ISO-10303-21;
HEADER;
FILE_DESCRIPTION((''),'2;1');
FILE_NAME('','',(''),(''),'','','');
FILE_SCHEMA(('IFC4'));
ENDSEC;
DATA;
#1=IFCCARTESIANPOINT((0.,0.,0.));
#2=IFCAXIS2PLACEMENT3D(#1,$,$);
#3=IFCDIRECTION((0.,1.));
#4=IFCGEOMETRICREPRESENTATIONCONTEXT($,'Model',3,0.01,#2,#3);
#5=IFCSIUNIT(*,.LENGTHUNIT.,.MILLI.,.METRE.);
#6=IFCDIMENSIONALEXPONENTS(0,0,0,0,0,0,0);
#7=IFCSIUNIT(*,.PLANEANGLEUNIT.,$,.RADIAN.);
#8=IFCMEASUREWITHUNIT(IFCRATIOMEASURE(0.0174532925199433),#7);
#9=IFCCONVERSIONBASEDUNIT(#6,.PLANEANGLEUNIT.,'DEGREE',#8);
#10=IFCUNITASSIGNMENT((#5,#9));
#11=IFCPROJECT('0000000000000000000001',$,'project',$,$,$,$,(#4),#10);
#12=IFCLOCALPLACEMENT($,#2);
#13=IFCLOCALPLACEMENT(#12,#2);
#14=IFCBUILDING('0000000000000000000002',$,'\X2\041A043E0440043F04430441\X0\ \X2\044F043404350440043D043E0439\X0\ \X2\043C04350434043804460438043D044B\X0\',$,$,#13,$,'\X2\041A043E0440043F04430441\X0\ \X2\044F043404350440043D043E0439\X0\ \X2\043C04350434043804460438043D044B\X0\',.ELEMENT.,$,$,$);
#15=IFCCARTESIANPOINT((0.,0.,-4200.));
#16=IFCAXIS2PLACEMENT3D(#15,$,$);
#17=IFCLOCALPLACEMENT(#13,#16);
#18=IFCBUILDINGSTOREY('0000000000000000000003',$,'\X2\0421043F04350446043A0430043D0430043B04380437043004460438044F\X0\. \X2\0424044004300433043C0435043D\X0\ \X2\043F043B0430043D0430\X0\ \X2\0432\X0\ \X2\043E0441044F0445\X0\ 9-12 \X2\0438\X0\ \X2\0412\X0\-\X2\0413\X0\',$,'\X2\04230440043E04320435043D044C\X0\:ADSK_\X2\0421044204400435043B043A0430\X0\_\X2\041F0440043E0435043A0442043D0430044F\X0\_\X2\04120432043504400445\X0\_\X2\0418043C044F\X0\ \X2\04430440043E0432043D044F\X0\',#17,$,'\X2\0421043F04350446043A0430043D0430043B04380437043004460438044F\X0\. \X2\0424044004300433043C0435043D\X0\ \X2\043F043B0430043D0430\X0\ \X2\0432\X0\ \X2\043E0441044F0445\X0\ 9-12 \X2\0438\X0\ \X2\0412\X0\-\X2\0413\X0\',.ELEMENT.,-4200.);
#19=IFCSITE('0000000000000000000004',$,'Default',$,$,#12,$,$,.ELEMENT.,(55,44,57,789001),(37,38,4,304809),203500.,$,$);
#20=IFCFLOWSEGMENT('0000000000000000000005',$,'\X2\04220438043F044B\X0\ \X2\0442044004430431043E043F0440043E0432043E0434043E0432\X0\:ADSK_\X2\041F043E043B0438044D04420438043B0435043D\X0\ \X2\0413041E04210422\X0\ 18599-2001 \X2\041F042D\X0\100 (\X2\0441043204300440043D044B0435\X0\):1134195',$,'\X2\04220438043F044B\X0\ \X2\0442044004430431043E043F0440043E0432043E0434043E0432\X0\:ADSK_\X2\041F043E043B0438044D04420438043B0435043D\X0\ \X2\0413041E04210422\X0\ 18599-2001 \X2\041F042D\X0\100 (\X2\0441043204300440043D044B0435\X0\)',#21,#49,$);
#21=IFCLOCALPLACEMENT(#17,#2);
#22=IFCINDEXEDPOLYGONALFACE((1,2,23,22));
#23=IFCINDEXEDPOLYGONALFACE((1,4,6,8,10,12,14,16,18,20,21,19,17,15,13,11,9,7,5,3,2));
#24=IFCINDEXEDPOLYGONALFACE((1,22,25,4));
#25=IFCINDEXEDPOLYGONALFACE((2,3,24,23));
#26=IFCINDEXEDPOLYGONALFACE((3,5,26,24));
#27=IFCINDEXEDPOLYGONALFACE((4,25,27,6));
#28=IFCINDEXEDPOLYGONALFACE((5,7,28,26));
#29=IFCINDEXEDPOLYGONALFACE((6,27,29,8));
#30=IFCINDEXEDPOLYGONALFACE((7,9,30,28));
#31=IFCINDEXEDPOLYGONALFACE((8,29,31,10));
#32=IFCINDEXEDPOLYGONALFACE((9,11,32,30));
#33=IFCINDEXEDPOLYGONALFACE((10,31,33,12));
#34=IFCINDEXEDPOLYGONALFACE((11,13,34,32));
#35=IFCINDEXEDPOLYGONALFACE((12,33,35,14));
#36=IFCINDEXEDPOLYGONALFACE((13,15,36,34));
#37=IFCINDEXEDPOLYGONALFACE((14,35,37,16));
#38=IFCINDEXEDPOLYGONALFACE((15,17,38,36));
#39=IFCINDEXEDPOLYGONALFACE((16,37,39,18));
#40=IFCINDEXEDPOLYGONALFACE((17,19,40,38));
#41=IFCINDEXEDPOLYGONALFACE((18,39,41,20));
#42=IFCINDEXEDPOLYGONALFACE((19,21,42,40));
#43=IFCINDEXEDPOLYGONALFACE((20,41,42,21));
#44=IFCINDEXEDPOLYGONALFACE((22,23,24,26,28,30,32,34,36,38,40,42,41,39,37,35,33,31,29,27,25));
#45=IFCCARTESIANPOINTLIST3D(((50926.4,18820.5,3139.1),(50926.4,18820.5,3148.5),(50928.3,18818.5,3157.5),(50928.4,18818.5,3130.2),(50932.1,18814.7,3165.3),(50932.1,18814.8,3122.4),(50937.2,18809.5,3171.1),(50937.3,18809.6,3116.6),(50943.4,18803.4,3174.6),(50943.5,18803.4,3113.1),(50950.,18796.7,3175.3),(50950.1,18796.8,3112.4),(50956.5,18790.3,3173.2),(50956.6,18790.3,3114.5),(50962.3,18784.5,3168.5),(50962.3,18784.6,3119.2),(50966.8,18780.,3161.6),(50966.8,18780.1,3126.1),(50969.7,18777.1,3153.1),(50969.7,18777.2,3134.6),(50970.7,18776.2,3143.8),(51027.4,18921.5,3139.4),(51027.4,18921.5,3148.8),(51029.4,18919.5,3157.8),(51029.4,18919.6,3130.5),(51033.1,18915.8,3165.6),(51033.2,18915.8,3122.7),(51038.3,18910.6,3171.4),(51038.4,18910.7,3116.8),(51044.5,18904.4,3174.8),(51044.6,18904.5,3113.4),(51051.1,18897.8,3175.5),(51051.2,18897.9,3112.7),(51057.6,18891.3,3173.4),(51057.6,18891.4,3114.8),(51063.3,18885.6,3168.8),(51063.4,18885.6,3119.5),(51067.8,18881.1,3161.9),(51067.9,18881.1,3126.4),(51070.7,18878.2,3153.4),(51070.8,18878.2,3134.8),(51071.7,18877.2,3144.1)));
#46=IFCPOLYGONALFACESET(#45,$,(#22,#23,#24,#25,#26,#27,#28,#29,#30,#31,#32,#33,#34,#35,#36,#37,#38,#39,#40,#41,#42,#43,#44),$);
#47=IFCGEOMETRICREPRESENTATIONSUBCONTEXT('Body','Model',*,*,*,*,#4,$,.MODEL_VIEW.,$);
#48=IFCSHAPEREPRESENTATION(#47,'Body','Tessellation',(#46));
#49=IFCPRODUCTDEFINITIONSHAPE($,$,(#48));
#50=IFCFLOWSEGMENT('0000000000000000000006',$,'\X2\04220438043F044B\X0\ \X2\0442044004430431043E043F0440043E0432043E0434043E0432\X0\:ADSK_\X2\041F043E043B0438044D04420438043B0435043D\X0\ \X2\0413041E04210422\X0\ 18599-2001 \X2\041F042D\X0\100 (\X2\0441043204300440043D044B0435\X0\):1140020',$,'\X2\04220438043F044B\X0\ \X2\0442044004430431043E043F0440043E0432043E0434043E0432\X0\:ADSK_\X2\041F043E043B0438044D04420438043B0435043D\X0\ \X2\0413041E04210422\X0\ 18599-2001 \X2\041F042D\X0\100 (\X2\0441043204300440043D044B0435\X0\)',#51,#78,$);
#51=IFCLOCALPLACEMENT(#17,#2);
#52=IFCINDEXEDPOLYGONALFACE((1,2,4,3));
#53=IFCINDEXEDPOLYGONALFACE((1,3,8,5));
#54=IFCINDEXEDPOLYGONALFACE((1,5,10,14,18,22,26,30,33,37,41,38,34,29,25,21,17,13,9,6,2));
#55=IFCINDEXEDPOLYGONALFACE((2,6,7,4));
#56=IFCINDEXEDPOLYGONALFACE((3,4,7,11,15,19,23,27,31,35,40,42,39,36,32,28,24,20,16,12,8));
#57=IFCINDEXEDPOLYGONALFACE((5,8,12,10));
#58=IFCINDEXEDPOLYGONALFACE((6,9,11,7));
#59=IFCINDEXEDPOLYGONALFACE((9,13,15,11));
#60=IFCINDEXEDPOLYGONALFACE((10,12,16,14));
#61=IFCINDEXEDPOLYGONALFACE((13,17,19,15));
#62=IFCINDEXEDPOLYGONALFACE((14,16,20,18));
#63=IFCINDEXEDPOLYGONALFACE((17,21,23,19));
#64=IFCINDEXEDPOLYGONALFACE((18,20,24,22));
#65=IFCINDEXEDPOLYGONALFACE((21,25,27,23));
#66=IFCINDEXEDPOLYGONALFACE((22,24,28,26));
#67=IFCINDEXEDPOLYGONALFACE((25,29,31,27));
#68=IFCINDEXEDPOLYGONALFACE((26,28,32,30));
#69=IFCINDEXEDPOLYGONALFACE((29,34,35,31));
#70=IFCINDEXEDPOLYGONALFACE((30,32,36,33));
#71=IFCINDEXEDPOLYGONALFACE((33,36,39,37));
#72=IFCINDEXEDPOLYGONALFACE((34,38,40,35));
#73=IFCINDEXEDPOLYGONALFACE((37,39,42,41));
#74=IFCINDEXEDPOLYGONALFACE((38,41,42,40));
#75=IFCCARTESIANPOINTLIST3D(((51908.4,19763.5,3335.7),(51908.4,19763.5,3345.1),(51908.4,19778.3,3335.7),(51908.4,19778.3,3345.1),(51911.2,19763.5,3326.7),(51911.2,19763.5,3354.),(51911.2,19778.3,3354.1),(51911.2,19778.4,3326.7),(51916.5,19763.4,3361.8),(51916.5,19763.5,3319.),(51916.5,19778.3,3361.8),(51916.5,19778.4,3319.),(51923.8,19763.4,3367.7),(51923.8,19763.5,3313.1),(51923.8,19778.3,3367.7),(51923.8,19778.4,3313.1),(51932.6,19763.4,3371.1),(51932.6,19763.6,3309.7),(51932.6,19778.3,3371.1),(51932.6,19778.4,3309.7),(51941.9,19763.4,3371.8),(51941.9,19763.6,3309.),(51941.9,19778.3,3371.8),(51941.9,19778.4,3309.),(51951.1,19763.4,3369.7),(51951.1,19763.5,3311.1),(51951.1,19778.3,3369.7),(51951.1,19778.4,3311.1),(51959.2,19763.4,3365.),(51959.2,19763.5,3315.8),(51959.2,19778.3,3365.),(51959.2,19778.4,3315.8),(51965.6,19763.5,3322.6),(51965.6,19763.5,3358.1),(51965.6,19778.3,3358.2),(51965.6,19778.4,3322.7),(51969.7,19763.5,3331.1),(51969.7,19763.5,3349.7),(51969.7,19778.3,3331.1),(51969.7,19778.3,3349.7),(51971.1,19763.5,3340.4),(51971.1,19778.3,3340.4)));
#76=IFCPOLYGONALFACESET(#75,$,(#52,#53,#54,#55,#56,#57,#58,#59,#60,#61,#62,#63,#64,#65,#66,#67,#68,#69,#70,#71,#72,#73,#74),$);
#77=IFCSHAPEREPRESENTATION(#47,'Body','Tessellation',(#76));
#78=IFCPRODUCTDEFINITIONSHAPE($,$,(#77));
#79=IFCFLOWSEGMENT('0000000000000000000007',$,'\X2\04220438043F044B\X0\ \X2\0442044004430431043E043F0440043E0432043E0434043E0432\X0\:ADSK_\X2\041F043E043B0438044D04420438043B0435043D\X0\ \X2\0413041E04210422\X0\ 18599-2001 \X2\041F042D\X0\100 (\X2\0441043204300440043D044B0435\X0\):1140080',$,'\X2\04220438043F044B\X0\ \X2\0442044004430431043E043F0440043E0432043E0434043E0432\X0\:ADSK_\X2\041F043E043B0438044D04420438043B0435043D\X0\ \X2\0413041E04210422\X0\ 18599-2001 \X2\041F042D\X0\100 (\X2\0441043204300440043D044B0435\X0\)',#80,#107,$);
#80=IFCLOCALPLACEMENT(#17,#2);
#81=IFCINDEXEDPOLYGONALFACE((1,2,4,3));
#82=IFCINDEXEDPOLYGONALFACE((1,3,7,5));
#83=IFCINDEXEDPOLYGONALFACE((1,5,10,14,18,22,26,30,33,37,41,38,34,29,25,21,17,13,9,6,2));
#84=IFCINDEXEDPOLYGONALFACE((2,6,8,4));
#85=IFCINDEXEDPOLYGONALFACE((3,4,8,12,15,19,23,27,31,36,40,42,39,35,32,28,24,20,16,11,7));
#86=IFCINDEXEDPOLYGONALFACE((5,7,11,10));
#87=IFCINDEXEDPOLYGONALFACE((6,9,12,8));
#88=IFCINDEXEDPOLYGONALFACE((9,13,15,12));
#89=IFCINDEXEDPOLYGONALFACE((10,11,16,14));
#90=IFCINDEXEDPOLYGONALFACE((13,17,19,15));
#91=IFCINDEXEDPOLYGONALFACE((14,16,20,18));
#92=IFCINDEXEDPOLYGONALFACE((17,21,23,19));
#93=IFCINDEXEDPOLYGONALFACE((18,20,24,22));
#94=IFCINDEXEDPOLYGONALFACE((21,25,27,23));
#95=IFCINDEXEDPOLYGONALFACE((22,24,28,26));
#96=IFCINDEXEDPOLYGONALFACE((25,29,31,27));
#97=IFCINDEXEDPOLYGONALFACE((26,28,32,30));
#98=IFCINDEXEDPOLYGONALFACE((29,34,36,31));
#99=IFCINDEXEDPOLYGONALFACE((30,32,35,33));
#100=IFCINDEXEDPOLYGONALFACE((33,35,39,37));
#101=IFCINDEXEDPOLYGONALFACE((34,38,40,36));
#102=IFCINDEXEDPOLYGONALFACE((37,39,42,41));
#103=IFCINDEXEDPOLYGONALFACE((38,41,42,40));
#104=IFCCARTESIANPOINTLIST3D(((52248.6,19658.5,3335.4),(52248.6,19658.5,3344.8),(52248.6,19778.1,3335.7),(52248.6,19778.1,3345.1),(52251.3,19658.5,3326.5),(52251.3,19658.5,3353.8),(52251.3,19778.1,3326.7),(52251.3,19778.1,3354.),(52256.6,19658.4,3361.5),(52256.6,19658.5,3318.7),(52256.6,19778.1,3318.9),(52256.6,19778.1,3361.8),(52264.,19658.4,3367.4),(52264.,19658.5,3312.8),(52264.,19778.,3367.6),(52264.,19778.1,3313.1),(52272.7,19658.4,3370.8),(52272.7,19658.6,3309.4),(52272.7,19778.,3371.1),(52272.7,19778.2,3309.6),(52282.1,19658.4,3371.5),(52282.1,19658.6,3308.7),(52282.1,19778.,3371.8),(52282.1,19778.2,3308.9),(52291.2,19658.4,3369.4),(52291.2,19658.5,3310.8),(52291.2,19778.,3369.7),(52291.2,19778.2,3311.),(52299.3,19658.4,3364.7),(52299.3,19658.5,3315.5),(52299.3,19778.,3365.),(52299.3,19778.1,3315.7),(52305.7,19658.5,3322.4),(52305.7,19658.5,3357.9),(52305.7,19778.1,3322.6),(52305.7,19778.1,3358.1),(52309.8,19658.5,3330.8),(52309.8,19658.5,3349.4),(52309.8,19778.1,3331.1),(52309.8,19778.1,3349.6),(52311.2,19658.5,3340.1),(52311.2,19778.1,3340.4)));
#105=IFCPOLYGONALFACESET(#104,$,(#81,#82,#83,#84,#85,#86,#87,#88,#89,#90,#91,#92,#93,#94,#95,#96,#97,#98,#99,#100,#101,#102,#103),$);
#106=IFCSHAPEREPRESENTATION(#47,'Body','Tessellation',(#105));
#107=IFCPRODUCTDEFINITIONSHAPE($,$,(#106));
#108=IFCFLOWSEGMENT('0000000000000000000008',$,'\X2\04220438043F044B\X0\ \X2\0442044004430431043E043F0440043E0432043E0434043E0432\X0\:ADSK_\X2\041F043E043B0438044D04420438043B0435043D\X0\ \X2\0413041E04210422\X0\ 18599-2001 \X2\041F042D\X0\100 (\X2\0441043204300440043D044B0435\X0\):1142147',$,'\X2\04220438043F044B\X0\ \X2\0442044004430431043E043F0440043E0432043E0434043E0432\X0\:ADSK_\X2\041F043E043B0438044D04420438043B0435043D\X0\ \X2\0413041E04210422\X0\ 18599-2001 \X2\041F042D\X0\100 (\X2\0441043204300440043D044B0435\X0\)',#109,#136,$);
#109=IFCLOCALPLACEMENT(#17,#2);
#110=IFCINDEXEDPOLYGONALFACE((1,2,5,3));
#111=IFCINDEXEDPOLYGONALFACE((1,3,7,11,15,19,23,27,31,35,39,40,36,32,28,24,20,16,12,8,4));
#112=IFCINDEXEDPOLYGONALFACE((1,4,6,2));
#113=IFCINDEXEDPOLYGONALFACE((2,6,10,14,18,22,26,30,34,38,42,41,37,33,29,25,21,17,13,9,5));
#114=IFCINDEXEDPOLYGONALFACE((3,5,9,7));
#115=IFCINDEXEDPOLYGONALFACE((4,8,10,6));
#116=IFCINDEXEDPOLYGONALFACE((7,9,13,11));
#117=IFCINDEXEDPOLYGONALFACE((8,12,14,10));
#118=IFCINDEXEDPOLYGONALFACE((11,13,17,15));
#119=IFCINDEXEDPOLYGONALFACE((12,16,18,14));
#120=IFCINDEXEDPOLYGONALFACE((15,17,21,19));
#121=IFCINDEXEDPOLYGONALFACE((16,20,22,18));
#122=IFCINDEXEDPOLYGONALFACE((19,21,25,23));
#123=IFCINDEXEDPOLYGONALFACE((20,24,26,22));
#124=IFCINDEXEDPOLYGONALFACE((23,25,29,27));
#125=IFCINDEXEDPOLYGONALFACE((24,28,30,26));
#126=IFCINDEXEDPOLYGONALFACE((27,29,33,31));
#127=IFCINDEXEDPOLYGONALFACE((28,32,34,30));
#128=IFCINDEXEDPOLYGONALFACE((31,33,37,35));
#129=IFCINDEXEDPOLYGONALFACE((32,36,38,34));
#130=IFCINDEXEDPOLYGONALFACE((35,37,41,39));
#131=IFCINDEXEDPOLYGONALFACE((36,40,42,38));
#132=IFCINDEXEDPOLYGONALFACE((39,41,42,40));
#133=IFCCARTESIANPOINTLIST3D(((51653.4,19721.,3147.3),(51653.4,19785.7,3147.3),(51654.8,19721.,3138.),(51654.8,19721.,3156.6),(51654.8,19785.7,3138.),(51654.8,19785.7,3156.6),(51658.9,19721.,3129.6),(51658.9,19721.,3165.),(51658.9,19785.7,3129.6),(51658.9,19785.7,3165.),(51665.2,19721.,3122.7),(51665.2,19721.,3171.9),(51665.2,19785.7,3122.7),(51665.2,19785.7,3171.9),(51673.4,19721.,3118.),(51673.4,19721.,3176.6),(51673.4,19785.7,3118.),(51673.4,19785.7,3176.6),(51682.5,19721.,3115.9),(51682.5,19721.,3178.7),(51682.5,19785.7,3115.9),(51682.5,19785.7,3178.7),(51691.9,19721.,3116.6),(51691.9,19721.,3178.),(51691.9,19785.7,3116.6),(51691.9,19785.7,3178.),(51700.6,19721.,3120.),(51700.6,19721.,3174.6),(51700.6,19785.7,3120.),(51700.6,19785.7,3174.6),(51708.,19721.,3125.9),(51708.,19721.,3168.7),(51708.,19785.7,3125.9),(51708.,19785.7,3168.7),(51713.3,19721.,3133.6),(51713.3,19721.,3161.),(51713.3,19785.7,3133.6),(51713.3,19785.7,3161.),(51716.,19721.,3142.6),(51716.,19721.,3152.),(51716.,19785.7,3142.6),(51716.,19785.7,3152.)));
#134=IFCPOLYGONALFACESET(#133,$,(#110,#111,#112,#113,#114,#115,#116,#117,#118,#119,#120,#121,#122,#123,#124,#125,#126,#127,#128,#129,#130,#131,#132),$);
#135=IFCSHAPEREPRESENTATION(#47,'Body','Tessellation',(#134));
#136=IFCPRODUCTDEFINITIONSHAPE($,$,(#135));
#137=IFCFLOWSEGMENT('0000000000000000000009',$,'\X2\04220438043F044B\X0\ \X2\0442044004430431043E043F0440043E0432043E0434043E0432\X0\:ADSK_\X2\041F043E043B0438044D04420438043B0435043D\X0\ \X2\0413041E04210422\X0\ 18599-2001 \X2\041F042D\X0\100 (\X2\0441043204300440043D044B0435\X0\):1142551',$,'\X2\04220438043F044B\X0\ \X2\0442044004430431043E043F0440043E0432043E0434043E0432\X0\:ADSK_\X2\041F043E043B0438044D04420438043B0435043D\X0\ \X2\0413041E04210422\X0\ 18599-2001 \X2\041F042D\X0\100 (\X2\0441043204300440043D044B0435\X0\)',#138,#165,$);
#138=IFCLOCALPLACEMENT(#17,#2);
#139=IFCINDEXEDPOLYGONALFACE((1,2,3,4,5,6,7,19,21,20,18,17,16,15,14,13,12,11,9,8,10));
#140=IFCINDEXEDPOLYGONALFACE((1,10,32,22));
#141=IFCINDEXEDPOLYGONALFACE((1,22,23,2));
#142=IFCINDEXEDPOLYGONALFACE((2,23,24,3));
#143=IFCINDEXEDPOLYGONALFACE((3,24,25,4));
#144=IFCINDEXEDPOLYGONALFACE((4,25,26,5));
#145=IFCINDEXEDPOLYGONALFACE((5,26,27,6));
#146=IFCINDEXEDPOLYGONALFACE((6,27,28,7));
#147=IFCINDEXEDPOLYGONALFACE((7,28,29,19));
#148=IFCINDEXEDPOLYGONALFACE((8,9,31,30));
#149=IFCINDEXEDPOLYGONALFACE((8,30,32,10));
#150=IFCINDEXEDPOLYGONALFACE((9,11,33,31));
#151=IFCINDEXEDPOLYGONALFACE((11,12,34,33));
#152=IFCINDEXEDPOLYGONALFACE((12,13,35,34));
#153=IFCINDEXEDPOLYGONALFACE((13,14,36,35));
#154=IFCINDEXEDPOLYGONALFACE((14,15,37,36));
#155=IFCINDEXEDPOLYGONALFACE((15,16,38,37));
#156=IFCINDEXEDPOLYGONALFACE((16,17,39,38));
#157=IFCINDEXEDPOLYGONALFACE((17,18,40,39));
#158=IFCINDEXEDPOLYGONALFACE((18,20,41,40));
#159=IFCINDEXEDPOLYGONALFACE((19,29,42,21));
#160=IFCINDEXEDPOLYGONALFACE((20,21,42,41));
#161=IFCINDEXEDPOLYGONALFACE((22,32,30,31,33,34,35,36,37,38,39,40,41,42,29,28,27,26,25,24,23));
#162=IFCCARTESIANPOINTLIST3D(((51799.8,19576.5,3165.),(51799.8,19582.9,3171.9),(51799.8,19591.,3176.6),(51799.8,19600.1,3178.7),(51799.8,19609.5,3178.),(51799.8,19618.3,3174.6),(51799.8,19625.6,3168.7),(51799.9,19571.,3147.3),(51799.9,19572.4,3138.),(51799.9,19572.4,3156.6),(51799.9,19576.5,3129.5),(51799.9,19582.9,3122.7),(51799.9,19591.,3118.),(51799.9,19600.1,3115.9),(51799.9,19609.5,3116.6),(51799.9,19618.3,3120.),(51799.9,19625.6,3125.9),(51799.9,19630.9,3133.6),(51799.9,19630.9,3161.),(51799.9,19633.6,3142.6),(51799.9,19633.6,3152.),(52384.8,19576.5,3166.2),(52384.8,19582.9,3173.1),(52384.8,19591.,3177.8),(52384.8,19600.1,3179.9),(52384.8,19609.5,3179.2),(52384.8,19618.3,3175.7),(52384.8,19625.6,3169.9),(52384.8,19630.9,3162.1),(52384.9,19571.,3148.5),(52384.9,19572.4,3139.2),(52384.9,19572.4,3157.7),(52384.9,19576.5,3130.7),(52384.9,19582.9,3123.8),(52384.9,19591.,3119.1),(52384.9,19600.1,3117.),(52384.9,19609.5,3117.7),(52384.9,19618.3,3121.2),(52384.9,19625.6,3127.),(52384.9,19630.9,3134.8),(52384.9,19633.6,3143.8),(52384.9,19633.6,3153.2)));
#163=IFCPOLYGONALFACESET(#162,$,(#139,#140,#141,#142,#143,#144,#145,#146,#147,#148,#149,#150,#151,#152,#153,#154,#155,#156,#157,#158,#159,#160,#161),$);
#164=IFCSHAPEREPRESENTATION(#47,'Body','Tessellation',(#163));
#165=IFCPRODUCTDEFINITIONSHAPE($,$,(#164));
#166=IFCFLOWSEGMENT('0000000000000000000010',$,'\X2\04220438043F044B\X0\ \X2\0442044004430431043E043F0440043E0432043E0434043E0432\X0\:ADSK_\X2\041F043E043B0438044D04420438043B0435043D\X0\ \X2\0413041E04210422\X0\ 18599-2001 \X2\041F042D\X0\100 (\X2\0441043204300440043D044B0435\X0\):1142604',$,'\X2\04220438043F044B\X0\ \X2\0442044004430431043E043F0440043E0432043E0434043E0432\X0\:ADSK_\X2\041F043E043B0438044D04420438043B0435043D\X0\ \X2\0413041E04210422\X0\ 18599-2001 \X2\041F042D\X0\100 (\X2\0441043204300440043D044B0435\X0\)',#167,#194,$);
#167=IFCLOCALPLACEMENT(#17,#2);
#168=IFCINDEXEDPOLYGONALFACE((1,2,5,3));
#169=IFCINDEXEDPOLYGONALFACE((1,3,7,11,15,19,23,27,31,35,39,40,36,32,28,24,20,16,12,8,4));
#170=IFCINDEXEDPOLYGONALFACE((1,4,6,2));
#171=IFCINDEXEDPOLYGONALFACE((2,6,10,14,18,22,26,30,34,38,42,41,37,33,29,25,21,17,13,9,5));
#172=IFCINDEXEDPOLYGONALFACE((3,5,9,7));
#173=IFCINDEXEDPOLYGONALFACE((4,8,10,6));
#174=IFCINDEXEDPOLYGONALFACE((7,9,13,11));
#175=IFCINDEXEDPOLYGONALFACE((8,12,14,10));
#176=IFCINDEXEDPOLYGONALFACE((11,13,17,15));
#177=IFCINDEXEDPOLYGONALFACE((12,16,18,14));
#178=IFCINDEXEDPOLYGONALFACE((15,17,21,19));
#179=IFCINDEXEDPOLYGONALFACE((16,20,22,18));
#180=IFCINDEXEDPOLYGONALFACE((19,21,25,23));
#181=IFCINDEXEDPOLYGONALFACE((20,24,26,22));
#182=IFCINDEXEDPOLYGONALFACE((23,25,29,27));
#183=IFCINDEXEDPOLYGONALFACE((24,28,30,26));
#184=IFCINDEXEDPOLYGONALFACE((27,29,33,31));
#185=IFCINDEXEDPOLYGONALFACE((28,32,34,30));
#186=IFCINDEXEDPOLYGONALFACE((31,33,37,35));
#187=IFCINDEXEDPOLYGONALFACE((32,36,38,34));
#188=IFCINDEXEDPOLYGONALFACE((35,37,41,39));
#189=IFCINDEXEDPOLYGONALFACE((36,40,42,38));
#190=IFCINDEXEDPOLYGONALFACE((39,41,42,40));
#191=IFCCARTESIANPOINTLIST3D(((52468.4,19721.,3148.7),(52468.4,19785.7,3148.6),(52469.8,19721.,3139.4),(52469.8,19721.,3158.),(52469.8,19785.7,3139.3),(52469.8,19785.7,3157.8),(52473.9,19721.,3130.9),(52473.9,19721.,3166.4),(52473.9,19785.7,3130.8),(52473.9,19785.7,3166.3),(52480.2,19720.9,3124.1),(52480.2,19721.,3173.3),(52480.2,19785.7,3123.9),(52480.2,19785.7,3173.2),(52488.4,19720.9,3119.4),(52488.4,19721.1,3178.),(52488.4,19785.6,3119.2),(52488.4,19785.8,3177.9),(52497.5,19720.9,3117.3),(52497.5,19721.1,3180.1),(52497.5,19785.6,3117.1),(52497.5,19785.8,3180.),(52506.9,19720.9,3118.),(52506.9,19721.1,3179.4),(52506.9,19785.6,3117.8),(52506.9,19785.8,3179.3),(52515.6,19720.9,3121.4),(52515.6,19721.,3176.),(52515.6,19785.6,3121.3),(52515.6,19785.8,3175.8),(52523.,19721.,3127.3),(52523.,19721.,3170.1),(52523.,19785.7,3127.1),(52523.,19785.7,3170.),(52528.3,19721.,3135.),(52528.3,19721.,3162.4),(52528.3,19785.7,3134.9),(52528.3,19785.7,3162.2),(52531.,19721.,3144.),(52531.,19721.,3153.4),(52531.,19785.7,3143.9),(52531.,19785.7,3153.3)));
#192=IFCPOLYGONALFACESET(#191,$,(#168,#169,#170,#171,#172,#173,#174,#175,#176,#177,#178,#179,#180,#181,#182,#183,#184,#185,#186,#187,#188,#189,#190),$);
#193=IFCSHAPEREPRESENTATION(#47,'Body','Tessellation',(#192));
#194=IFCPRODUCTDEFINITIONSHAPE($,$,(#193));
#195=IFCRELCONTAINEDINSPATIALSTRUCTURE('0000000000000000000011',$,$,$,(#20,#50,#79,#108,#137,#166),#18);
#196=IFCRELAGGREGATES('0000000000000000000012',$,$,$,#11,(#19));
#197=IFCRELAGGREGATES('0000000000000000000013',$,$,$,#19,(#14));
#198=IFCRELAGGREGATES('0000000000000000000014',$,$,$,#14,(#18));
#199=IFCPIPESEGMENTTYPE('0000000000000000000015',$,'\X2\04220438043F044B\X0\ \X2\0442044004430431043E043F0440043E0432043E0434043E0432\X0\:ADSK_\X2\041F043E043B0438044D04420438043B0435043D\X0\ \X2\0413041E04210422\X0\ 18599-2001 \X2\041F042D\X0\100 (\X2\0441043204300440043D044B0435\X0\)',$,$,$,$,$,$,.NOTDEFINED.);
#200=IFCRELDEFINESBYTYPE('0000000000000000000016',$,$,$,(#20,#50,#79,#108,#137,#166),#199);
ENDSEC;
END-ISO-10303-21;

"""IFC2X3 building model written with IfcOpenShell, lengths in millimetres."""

from ifc_helpers import new_model, entity, si_unit, converted_unit, direction, frame, origin, origin_2d_with_axis, place, context, subcontext, project, spatial, circle, extrude, type_object, element, save


model = new_model("IFC2X3")

# Units and contexts
model_context = context("Model", 3, precision=0.01, world=origin(), true_north=direction((0.0, 1.0)))
body_context = subcontext(model_context, "Body", "Model", "MODEL_VIEW")
ifc_project = project(units=[si_unit("LENGTHUNIT", "METRE", prefix="MILLI"), converted_unit("PLANEANGLEUNIT", "DEGREE", entity("IfcRatioMeasure", 0.0174532925199433), si_unit("PLANEANGLEUNIT", "RADIAN"), dimensions=[0, 0, 0, 0, 0, 0, 0])], contexts=[model_context])

# Site, building, storey
site_placement = place(None, origin())
site = spatial("IfcSite", under=ifc_project, at=site_placement, Name="Default", CompositionType="ELEMENT", RefLatitude=(55, 44, 57, 789001), RefLongitude=(37, 38, 4, 304809), RefElevation=203500.0)
building_placement = place(site_placement, origin())
building = spatial("IfcBuilding", under=site, at=building_placement, Name="Корпус ядерной медицины", LongName="Корпус ядерной медицины", CompositionType="ELEMENT")
storey_placement = place(building_placement, frame((0.0, 0.0, -4200.0)))
storey = spatial("IfcBuildingStorey", under=building, at=storey_placement, Name="Спецканализация. Фрагмен плана в осях 9-12 и В-Г", ObjectType="Уровень:ADSK_Стрелка_Проектная_Вверх_Имя уровня", LongName="Спецканализация. Фрагмен плана в осях 9-12 и В-Г", CompositionType="ELEMENT", Elevation=-4200.0)

# Flow segments
pipe_segment_type = type_object("IfcPipeSegmentType", Name="Типы трубопроводов:ADSK_Полиэтилен ГОСТ 18599-2001 ПЭ100 (сварные)", PredefinedType="NOTDEFINED")
flow_segment_1_placement = place(storey_placement, frame((50924.6, 18774.6, 3110.7)))
element("IfcFlowSegment", 1, at=flow_segment_1_placement, inside=storey, type_object=pipe_segment_type, Name="Типы трубопроводов:ADSK_Полиэтилен ГОСТ 18599-2001 ПЭ100 (сварные):1134195", ObjectType="Типы трубопроводов:ADSK_Полиэтилен ГОСТ 18599-2001 ПЭ100 (сварные)", context=body_context, shape_type="SweptSolid", body=[
    extrude(circle(Radius=31.5, at=origin_2d_with_axis()), frame((23.9, 23.9, 33.1), z_axis=(0.707105, 0.707105, 0.002), x_axis=(0.707107, -0.707107, 0.0)), (0.0, 0.0, 1.0), 142.9),
])
flow_segment_2_placement = place(storey_placement, frame((51906.5, 19763.4, 3307.3)))
element("IfcFlowSegment", 2, at=flow_segment_2_placement, inside=storey, type_object=pipe_segment_type, Name="Типы трубопроводов:ADSK_Полиэтилен ГОСТ 18599-2001 ПЭ100 (сварные):1140020", ObjectType="Типы трубопроводов:ADSK_Полиэтилен ГОСТ 18599-2001 ПЭ100 (сварные)", context=body_context, shape_type="SweptSolid", body=[
    extrude(circle(Radius=31.5, at=origin_2d_with_axis()), frame((33.1, 0.1, 33.1), z_axis=(0.0, 0.999998, 0.001994), x_axis=(1.0, 0.0, 0.0)), (0.0, 0.0, 1.0), 14.8),
])
flow_segment_3_placement = place(storey_placement, frame((52246.6, 19658.4, 3307.0)))
element("IfcFlowSegment", 3, at=flow_segment_3_placement, inside=storey, type_object=pipe_segment_type, Name="Типы трубопроводов:ADSK_Полиэтилен ГОСТ 18599-2001 ПЭ100 (сварные):1140080", ObjectType="Типы трубопроводов:ADSK_Полиэтилен ГОСТ 18599-2001 ПЭ100 (сварные)", context=body_context, shape_type="SweptSolid", body=[
    extrude(circle(Radius=31.5, at=origin_2d_with_axis()), frame((33.1, 0.1, 33.1), z_axis=(0.0, 0.999998, 0.002), x_axis=(1.0, 0.0, 0.0)), (0.0, 0.0, 1.0), 119.6),
])
flow_segment_4_placement = place(storey_placement, frame((51651.8, 19721.0, 3114.2)))
element("IfcFlowSegment", 4, at=flow_segment_4_placement, inside=storey, type_object=pipe_segment_type, Name="Типы трубопроводов:ADSK_Полиэтилен ГОСТ 18599-2001 ПЭ100 (сварные):1142147", ObjectType="Типы трубопроводов:ADSK_Полиэтилен ГОСТ 18599-2001 ПЭ100 (сварные)", context=body_context, shape_type="SweptSolid", body=[
    extrude(circle(Radius=31.5, at=origin_2d_with_axis()), frame((33.1, 0.0, 33.1), z_axis=(0.000002, 1.0, 0.0), x_axis=(-1.0, 0.000002, 0.0)), (0.0, 0.0, 1.0), 64.7),
])
flow_segment_5_placement = place(storey_placement, frame((51799.8, 19569.4, 3114.2)))
element("IfcFlowSegment", 5, at=flow_segment_5_placement, inside=storey, type_object=pipe_segment_type, Name="Типы трубопроводов:ADSK_Полиэтилен ГОСТ 18599-2001 ПЭ100 (сварные):1142551", ObjectType="Типы трубопроводов:ADSK_Полиэтилен ГОСТ 18599-2001 ПЭ100 (сварные)", context=body_context, shape_type="SweptSolid", body=[
    extrude(circle(Radius=31.5, at=origin_2d_with_axis()), frame((0.1, 33.1, 33.1), z_axis=(0.999998, 0.0, 0.001994), x_axis=(0.0, -1.0, 0.0)), (0.0, 0.0, 1.0), 585.0),
])
flow_segment_6_placement = place(storey_placement, frame((52466.8, 19720.9, 3115.5)))
element("IfcFlowSegment", 6, at=flow_segment_6_placement, inside=storey, type_object=pipe_segment_type, Name="Типы трубопроводов:ADSK_Полиэтилен ГОСТ 18599-2001 ПЭ100 (сварные):1142604", ObjectType="Типы трубопроводов:ADSK_Полиэтилен ГОСТ 18599-2001 ПЭ100 (сварные)", context=body_context, shape_type="SweptSolid", body=[
    extrude(circle(Radius=31.5, at=origin_2d_with_axis()), frame((33.1, 64.8, 33.1), z_axis=(0.0, -0.999998, 0.002), x_axis=(-1.0, 0.0, 0.0)), (0.0, 0.0, 1.0), 64.7),
])

save(model, "model.ifc")
